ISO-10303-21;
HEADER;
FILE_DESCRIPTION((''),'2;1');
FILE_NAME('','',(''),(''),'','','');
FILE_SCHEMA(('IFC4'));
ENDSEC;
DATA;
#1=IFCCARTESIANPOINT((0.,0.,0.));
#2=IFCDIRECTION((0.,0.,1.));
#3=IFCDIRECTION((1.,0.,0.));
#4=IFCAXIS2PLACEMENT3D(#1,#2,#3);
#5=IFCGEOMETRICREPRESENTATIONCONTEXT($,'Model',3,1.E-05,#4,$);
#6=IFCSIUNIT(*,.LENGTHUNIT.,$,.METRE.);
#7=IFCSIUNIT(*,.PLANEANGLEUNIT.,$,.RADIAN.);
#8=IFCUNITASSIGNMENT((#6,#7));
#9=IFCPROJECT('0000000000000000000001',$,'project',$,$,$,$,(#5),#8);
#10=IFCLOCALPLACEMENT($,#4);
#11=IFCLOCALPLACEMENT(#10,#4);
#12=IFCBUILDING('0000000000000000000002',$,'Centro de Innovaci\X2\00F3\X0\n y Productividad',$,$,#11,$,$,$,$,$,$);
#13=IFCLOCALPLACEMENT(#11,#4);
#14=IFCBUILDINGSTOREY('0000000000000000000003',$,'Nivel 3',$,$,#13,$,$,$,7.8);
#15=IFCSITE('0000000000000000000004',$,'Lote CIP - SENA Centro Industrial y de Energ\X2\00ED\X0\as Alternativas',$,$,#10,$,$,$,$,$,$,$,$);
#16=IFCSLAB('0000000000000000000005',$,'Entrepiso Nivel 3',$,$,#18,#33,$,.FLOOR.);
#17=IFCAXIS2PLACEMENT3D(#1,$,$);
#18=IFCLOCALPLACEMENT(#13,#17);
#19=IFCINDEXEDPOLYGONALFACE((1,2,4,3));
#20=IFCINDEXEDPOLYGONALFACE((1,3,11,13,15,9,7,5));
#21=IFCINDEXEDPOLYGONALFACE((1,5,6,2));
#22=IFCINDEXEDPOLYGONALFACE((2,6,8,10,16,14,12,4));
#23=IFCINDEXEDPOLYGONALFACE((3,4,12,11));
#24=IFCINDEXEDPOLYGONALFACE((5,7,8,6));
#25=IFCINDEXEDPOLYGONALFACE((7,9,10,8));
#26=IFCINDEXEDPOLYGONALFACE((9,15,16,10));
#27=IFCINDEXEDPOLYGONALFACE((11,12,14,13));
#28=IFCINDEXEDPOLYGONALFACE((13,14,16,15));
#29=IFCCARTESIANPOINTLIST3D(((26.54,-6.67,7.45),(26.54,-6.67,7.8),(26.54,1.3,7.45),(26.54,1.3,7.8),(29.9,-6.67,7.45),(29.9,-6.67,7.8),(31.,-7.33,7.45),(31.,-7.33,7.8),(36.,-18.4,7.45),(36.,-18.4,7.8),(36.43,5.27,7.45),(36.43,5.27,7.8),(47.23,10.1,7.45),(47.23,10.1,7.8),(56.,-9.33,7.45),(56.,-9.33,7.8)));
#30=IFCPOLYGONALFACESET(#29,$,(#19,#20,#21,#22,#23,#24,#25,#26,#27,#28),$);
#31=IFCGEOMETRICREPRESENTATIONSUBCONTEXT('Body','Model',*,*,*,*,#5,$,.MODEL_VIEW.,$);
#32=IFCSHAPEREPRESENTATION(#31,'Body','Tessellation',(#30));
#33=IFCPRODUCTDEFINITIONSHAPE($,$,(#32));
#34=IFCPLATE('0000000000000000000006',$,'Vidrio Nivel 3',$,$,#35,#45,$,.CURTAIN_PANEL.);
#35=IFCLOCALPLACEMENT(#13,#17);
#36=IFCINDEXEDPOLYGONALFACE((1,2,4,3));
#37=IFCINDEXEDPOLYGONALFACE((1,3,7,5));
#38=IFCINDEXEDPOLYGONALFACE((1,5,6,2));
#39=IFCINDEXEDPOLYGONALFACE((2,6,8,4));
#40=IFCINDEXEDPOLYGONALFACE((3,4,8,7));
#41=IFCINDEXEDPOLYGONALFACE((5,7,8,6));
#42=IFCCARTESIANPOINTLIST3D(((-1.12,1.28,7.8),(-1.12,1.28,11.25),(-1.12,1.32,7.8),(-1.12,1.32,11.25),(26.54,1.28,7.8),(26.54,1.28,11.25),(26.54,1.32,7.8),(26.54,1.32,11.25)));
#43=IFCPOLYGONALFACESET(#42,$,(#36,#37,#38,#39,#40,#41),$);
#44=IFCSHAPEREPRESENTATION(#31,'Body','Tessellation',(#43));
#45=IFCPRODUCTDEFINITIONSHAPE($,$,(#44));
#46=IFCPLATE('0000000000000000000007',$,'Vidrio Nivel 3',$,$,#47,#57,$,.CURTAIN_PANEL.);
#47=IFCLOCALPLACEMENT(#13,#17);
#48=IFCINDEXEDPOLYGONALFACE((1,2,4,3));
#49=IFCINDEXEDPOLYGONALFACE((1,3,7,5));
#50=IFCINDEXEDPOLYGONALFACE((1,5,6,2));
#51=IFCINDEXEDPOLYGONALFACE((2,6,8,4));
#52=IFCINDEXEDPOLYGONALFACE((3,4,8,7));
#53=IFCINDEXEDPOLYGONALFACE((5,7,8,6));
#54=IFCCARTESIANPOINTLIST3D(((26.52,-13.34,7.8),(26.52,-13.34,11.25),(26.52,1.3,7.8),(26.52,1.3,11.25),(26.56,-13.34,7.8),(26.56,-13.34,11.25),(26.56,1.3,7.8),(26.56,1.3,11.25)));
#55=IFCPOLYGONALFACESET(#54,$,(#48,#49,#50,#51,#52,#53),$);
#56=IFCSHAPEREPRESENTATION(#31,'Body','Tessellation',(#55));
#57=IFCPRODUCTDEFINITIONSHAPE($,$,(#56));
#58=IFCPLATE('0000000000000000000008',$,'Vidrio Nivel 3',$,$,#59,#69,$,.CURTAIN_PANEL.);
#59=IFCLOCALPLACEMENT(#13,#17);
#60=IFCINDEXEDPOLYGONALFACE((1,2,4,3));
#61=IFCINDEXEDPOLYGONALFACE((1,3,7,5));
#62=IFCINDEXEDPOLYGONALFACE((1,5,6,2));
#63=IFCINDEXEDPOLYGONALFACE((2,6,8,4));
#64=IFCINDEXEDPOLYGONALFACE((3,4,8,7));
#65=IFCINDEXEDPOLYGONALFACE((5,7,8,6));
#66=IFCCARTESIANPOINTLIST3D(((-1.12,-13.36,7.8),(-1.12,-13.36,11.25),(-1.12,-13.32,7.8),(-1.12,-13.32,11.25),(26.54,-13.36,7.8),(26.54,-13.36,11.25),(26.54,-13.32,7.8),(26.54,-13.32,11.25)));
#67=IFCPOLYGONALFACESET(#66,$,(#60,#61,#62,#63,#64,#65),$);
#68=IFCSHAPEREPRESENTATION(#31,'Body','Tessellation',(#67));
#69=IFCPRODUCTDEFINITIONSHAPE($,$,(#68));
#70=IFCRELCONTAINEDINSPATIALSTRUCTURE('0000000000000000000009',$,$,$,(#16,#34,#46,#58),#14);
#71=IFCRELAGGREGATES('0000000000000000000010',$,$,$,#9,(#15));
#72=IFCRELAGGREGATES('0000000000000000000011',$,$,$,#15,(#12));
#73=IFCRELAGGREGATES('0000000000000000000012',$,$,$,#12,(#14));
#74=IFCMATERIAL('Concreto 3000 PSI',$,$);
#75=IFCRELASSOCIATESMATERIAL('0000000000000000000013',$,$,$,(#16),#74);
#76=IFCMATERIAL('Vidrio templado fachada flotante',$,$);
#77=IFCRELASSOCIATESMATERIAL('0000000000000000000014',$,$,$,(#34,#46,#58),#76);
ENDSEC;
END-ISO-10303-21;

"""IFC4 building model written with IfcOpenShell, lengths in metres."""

from ifc_helpers import new_model, si_unit, frame, origin_with_axes, place, context, subcontext, project, spatial, polyline, outline, extrude, material, element, save


model = new_model("IFC4")

# Units and contexts
model_context = context("Model", 3, precision=1e-05, world=origin_with_axes())
body_context = subcontext(model_context, "Body", "Model", "MODEL_VIEW")
ifc_project = project(units=[si_unit("LENGTHUNIT", "METRE"), si_unit("PLANEANGLEUNIT", "RADIAN")], contexts=[model_context])

# Site, building, storey
site_placement = place(None, origin_with_axes())
site = spatial("IfcSite", under=ifc_project, at=site_placement, Name="Lote CIP - SENA Centro Industrial y de Energías Alternativas")
building_placement = place(site_placement, origin_with_axes())
building = spatial("IfcBuilding", under=site, at=building_placement, Name="Centro de Innovación y Productividad")
storey_placement = place(building_placement, origin_with_axes())
storey = spatial("IfcBuildingStorey", under=building, at=storey_placement, Name="Nivel 3", Elevation=7.8)

# Slab
ifc_material_1 = material(Name="Concreto 3000 PSI")
slab_1_placement = place(storey_placement, origin_with_axes())
element("IfcSlab", 1, at=slab_1_placement, inside=storey, material=ifc_material_1, Name="Entrepiso Nivel 3", PredefinedType="FLOOR", context=body_context, shape_type="SweptSolid", body=[
    extrude(outline(polyline([(26.54, 1.3), (36.43, 5.27), (47.23, 10.1), (56.0, -9.33), (36.0, -18.4), (31.0, -7.33), (29.9, -6.67), (26.54, -6.67), (26.54, 1.3)])), frame((0.0, 0.0, 7.45)), (0.0, 0.0, 1.0), 0.35),
])

# Plates
ifc_material_2 = material(Name="Vidrio templado fachada flotante")
plate_1_placement = place(storey_placement, origin_with_axes())
element("IfcPlate", 2, at=plate_1_placement, inside=storey, material=ifc_material_2, Name="Vidrio Nivel 3", PredefinedType="CURTAIN_PANEL", context=body_context, shape_type="SweptSolid", body=[
    extrude(outline(polyline([(26.54, 1.28), (-1.12, 1.28), (-1.12, 1.32), (26.54, 1.32), (26.54, 1.28)])), frame((0.0, 0.0, 7.8)), (0.0, 0.0, 1.0), 3.45),
])
plate_2_placement = place(storey_placement, origin_with_axes())
element("IfcPlate", 3, at=plate_2_placement, inside=storey, material=ifc_material_2, Name="Vidrio Nivel 3", PredefinedType="CURTAIN_PANEL", context=body_context, shape_type="SweptSolid", body=[
    extrude(outline(polyline([(26.52, -13.34), (26.52, 1.3), (26.56, 1.3), (26.56, -13.34), (26.52, -13.34)])), frame((0.0, 0.0, 7.8)), (0.0, 0.0, 1.0), 3.45),
])
plate_3_placement = place(storey_placement, origin_with_axes())
element("IfcPlate", 4, at=plate_3_placement, inside=storey, material=ifc_material_2, Name="Vidrio Nivel 3", PredefinedType="CURTAIN_PANEL", context=body_context, shape_type="SweptSolid", body=[
    extrude(outline(polyline([(-1.12, -13.32), (26.54, -13.32), (26.54, -13.36), (-1.12, -13.36), (-1.12, -13.32)])), frame((0.0, 0.0, 7.8)), (0.0, 0.0, 1.0), 3.45),
])

save(model, "model.ifc")
